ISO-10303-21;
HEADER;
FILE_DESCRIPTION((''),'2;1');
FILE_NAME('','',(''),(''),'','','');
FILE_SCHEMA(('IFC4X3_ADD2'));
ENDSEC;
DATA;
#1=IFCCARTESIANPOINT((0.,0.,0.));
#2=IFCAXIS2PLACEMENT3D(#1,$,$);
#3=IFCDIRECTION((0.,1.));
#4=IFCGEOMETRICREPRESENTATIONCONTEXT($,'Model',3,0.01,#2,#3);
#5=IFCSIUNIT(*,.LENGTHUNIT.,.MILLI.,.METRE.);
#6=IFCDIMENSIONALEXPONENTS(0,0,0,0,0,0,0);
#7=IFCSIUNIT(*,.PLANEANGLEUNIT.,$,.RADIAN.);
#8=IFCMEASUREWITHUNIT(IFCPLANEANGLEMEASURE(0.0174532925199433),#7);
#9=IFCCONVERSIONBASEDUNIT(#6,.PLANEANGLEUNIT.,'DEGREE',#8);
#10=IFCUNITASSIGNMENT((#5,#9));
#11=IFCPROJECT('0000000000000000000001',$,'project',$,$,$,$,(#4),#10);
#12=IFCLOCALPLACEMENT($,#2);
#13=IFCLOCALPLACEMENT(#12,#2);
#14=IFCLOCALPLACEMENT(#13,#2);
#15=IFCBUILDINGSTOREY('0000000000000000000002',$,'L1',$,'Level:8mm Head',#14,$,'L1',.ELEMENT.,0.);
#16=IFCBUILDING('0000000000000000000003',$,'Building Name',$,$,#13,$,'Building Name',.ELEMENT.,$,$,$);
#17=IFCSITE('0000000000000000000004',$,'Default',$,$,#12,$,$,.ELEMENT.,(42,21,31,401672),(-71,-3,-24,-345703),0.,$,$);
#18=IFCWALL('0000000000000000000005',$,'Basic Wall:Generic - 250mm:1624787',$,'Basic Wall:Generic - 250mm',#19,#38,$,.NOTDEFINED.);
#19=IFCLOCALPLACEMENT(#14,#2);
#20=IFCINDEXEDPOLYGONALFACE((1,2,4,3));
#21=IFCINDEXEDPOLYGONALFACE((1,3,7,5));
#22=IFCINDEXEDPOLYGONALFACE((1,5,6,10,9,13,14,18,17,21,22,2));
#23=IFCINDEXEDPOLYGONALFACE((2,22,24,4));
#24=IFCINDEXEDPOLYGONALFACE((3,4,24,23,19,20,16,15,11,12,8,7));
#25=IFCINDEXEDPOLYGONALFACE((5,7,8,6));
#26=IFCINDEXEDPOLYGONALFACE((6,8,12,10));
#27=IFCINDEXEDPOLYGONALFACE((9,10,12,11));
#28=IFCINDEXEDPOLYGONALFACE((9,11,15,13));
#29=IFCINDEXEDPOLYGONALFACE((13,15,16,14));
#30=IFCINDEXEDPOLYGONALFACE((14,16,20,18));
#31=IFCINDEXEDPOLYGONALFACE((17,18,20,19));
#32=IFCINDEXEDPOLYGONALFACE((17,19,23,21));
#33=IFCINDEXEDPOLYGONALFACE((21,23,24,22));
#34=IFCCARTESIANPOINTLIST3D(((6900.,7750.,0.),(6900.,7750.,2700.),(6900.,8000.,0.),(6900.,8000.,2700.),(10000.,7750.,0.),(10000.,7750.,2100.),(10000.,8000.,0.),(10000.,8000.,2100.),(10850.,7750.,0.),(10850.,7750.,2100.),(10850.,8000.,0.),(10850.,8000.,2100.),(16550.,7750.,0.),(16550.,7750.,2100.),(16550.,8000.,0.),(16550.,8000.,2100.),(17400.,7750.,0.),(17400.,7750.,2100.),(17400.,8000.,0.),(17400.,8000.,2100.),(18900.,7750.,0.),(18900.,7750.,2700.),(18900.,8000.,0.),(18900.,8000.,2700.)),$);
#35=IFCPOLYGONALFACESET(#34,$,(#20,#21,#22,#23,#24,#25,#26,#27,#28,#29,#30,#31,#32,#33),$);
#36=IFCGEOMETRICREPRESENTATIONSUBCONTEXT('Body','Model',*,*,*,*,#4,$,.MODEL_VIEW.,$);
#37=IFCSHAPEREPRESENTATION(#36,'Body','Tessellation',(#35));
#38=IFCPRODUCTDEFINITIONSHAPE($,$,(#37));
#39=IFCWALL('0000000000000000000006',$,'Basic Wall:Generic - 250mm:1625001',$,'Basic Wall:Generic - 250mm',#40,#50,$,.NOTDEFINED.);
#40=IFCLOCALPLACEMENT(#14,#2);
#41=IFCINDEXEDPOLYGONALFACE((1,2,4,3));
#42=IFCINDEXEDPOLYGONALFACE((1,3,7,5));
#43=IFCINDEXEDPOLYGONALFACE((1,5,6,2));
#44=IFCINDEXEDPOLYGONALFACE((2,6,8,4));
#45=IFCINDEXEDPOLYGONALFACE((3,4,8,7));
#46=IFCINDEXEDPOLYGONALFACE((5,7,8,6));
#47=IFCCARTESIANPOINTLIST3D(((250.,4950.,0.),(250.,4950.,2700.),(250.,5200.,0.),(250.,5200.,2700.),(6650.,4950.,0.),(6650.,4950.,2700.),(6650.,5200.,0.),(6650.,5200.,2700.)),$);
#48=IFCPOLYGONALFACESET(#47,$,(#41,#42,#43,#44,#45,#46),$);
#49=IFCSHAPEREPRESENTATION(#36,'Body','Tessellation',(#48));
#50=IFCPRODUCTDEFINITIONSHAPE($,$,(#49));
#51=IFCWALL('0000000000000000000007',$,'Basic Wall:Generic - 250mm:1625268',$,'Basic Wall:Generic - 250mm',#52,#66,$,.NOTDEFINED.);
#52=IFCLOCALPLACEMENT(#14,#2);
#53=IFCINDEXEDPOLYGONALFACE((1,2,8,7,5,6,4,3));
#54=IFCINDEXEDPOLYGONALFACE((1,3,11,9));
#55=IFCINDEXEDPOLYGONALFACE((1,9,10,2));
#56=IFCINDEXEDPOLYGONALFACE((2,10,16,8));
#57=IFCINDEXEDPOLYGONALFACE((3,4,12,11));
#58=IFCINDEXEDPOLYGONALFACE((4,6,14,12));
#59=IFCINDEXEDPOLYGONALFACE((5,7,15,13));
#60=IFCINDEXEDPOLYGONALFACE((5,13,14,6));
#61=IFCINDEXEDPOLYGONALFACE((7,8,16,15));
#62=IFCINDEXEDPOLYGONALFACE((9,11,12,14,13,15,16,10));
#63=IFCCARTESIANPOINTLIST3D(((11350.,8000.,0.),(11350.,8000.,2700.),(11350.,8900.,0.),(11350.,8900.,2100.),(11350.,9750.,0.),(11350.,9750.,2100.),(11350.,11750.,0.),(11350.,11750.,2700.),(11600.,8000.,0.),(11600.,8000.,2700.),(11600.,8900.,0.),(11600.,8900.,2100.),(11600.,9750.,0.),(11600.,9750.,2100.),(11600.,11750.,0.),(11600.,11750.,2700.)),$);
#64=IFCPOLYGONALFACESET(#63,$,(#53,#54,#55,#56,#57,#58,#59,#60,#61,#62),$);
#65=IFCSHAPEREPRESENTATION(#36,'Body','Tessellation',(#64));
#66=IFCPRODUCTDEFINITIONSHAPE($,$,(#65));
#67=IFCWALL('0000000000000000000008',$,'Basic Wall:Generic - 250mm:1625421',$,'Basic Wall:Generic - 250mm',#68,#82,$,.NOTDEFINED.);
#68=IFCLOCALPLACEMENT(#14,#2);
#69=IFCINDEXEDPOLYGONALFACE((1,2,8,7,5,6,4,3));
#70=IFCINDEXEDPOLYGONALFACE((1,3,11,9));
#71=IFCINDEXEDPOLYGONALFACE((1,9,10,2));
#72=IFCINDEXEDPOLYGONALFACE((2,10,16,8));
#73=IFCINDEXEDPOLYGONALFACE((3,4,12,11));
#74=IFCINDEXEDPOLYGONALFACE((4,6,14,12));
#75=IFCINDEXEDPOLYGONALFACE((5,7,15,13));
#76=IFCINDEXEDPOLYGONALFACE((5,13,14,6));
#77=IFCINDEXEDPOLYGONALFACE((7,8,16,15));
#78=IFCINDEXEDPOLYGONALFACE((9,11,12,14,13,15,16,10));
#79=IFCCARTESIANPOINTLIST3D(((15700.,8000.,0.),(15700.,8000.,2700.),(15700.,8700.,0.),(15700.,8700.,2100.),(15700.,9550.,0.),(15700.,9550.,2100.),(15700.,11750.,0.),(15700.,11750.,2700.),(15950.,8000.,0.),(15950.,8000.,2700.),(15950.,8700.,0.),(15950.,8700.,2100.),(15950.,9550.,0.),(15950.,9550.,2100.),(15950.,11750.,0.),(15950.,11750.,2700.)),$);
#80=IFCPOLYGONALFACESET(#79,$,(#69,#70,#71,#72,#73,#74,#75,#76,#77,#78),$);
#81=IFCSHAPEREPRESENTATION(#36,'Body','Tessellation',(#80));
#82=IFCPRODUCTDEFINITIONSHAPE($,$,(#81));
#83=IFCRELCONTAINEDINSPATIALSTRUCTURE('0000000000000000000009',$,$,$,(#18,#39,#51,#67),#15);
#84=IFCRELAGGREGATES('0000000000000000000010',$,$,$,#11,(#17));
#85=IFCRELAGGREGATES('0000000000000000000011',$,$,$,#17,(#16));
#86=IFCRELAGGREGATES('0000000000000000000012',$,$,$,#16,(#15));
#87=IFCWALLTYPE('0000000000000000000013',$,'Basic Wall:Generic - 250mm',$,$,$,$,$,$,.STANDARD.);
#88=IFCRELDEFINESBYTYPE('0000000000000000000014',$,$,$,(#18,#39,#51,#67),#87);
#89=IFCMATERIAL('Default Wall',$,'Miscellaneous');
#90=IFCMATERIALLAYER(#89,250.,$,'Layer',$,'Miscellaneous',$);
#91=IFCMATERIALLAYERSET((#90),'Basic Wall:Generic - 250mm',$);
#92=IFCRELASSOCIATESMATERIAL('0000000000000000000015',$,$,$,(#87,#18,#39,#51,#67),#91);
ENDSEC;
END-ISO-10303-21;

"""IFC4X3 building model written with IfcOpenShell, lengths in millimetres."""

from ifc_helpers import new_model, entity, si_unit, converted_unit, direction, frame, frame_2d, origin, place, context, subcontext, project, spatial, rectangle, extrude, material, layer, layer_set, type_object, element, save


model = new_model("IFC4X3")

# Units and contexts
model_context = context("Model", 3, precision=0.01, world=origin(), true_north=direction((0.0, 1.0)))
body_context = subcontext(model_context, "Body", "Model", "MODEL_VIEW")
ifc_project = project(units=[si_unit("LENGTHUNIT", "METRE", prefix="MILLI"), converted_unit("PLANEANGLEUNIT", "DEGREE", entity("IfcPlaneAngleMeasure", 0.0174532925199433), si_unit("PLANEANGLEUNIT", "RADIAN"), dimensions=[0, 0, 0, 0, 0, 0, 0])], contexts=[model_context])

# Site, building, storey
site_placement = place(None, origin())
site = spatial("IfcSite", under=ifc_project, at=site_placement, Name="Default", CompositionType="ELEMENT", RefLatitude=(42, 21, 31, 401672), RefLongitude=(-71, -3, -24, -345703), RefElevation=0.0)
building_placement = place(site_placement, origin())
building = spatial("IfcBuilding", under=site, at=building_placement, Name="Building Name", LongName="Building Name", CompositionType="ELEMENT")
storey_placement = place(building_placement, origin())
storey = spatial("IfcBuildingStorey", under=building, at=storey_placement, Name="L1", ObjectType="Level:8mm Head", LongName="L1", CompositionType="ELEMENT", Elevation=0.0)

# Shared definitions
ifc_material_1 = material(Name="Default Wall", Category="Miscellaneous")
ifc_layer = layer(ifc_material_1, 250.0, Name="Layer", Category="Miscellaneous")
ifc_layer_set = layer_set([ifc_layer], Name="Basic Wall:Generic - 250mm")
wall_type = type_object("IfcWallType", Name="Basic Wall:Generic - 250mm", PredefinedType="STANDARD", material=ifc_layer_set)

# Wall, openings
wall_1_placement = place(storey_placement, frame((6900.0, 7875.0, 0.0)))
wall_1 = element("IfcWall", 1, at=wall_1_placement, inside=storey, type_object=wall_type, material=ifc_layer_set, Name="Basic Wall:Generic - 250mm:1624787", ObjectType="Basic Wall:Generic - 250mm", PredefinedType="NOTDEFINED", context=body_context, shape_type="SweptSolid", body=[
    extrude(rectangle(XDim=12000.0, YDim=250.0, at=frame_2d((6000.0, 0.0), x_axis=(1.0, 0.0))), origin(), (0.0, 0.0, 1.0), 2700.0),
])
opening_1_placement = place(wall_1_placement, frame((3100.0, -125.0, 0.0)))
element("IfcOpeningElement", 2, at=opening_1_placement, cuts=wall_1, PredefinedType="OPENING", context=body_context, shape_type="SweptSolid", body=[
    extrude(rectangle(XDim=2100.0, YDim=850.0, at=frame_2d((1050.0, 425.0), x_axis=(1.0, 0.0))), frame((0.0, 0.0, 0.0), z_axis=(0.0, 1.0, 0.0), x_axis=(0.0, 0.0, 1.0)), (0.0, 0.0, 1.0), 250.0),
])
opening_2_placement = place(wall_1_placement, frame((9650.0, -125.0, 0.0)))
element("IfcOpeningElement", 3, at=opening_2_placement, cuts=wall_1, PredefinedType="OPENING", context=body_context, shape_type="SweptSolid", body=[
    extrude(rectangle(XDim=2100.0, YDim=850.0, at=frame_2d((1050.0, 425.0), x_axis=(1.0, 0.0))), frame((0.0, 0.0, 0.0), z_axis=(0.0, 1.0, 0.0), x_axis=(0.0, 0.0, 1.0)), (0.0, 0.0, 1.0), 250.0),
])

# Wall
wall_2_placement = place(storey_placement, frame((6650.0, 5075.0, 0.0), z_axis=(0.0, 0.0, 1.0), x_axis=(-1.0, 0.0, 0.0)))
element("IfcWall", 4, at=wall_2_placement, inside=storey, type_object=wall_type, material=ifc_layer_set, Name="Basic Wall:Generic - 250mm:1625001", ObjectType="Basic Wall:Generic - 250mm", PredefinedType="NOTDEFINED", context=body_context, shape_type="SweptSolid", body=[
    extrude(rectangle(XDim=6400.0, YDim=250.0, at=frame_2d((3200.0, 0.0), x_axis=(-1.0, 0.0))), origin(), (0.0, 0.0, 1.0), 2700.0),
])

# Walls, openings
wall_3_placement = place(storey_placement, frame((11475.0, 8000.0, 0.0), z_axis=(0.0, 0.0, 1.0), x_axis=(0.0, 1.0, 0.0)))
wall_3 = element("IfcWall", 5, at=wall_3_placement, inside=storey, type_object=wall_type, material=ifc_layer_set, Name="Basic Wall:Generic - 250mm:1625268", ObjectType="Basic Wall:Generic - 250mm", PredefinedType="NOTDEFINED", context=body_context, shape_type="SweptSolid", body=[
    extrude(rectangle(XDim=3750.0, YDim=250.0, at=frame_2d((1875.0, 0.0), x_axis=(1.0, 0.0))), origin(), (0.0, 0.0, 1.0), 2700.0),
])
opening_3_placement = place(wall_3_placement, frame((1750.0, 125.0, 0.0)))
element("IfcOpeningElement", 6, at=opening_3_placement, cuts=wall_3, PredefinedType="OPENING", context=body_context, shape_type="SweptSolid", body=[
    extrude(rectangle(XDim=2100.0, YDim=850.0, at=frame_2d((1050.0, 425.0), x_axis=(1.0, 0.0))), frame((0.0, 0.0, 0.0), z_axis=(0.0, -1.0, 0.0), x_axis=(0.0, 0.0, 1.0)), (0.0, 0.0, 1.0), 250.0),
])
wall_4_placement = place(storey_placement, frame((15825.0, 8000.0, 0.0), z_axis=(0.0, 0.0, 1.0), x_axis=(0.0, 1.0, 0.0)))
wall_4 = element("IfcWall", 7, at=wall_4_placement, inside=storey, type_object=wall_type, material=ifc_layer_set, Name="Basic Wall:Generic - 250mm:1625421", ObjectType="Basic Wall:Generic - 250mm", PredefinedType="NOTDEFINED", context=body_context, shape_type="SweptSolid", body=[
    extrude(rectangle(XDim=3750.0, YDim=250.0, at=frame_2d((1875.0, 0.0), x_axis=(1.0, 0.0))), origin(), (0.0, 0.0, 1.0), 2700.0),
])
opening_4_placement = place(wall_4_placement, frame((700.0, -125.0, 0.0)))
element("IfcOpeningElement", 8, at=opening_4_placement, cuts=wall_4, PredefinedType="OPENING", context=body_context, shape_type="SweptSolid", body=[
    extrude(rectangle(XDim=2100.0, YDim=850.0, at=frame_2d((1050.0, 425.0), x_axis=(1.0, 0.0))), frame((0.0, 0.0, 0.0), z_axis=(0.0, 1.0, 0.0), x_axis=(0.0, 0.0, 1.0)), (0.0, 0.0, 1.0), 250.0),
])

save(model, "model.ifc")
